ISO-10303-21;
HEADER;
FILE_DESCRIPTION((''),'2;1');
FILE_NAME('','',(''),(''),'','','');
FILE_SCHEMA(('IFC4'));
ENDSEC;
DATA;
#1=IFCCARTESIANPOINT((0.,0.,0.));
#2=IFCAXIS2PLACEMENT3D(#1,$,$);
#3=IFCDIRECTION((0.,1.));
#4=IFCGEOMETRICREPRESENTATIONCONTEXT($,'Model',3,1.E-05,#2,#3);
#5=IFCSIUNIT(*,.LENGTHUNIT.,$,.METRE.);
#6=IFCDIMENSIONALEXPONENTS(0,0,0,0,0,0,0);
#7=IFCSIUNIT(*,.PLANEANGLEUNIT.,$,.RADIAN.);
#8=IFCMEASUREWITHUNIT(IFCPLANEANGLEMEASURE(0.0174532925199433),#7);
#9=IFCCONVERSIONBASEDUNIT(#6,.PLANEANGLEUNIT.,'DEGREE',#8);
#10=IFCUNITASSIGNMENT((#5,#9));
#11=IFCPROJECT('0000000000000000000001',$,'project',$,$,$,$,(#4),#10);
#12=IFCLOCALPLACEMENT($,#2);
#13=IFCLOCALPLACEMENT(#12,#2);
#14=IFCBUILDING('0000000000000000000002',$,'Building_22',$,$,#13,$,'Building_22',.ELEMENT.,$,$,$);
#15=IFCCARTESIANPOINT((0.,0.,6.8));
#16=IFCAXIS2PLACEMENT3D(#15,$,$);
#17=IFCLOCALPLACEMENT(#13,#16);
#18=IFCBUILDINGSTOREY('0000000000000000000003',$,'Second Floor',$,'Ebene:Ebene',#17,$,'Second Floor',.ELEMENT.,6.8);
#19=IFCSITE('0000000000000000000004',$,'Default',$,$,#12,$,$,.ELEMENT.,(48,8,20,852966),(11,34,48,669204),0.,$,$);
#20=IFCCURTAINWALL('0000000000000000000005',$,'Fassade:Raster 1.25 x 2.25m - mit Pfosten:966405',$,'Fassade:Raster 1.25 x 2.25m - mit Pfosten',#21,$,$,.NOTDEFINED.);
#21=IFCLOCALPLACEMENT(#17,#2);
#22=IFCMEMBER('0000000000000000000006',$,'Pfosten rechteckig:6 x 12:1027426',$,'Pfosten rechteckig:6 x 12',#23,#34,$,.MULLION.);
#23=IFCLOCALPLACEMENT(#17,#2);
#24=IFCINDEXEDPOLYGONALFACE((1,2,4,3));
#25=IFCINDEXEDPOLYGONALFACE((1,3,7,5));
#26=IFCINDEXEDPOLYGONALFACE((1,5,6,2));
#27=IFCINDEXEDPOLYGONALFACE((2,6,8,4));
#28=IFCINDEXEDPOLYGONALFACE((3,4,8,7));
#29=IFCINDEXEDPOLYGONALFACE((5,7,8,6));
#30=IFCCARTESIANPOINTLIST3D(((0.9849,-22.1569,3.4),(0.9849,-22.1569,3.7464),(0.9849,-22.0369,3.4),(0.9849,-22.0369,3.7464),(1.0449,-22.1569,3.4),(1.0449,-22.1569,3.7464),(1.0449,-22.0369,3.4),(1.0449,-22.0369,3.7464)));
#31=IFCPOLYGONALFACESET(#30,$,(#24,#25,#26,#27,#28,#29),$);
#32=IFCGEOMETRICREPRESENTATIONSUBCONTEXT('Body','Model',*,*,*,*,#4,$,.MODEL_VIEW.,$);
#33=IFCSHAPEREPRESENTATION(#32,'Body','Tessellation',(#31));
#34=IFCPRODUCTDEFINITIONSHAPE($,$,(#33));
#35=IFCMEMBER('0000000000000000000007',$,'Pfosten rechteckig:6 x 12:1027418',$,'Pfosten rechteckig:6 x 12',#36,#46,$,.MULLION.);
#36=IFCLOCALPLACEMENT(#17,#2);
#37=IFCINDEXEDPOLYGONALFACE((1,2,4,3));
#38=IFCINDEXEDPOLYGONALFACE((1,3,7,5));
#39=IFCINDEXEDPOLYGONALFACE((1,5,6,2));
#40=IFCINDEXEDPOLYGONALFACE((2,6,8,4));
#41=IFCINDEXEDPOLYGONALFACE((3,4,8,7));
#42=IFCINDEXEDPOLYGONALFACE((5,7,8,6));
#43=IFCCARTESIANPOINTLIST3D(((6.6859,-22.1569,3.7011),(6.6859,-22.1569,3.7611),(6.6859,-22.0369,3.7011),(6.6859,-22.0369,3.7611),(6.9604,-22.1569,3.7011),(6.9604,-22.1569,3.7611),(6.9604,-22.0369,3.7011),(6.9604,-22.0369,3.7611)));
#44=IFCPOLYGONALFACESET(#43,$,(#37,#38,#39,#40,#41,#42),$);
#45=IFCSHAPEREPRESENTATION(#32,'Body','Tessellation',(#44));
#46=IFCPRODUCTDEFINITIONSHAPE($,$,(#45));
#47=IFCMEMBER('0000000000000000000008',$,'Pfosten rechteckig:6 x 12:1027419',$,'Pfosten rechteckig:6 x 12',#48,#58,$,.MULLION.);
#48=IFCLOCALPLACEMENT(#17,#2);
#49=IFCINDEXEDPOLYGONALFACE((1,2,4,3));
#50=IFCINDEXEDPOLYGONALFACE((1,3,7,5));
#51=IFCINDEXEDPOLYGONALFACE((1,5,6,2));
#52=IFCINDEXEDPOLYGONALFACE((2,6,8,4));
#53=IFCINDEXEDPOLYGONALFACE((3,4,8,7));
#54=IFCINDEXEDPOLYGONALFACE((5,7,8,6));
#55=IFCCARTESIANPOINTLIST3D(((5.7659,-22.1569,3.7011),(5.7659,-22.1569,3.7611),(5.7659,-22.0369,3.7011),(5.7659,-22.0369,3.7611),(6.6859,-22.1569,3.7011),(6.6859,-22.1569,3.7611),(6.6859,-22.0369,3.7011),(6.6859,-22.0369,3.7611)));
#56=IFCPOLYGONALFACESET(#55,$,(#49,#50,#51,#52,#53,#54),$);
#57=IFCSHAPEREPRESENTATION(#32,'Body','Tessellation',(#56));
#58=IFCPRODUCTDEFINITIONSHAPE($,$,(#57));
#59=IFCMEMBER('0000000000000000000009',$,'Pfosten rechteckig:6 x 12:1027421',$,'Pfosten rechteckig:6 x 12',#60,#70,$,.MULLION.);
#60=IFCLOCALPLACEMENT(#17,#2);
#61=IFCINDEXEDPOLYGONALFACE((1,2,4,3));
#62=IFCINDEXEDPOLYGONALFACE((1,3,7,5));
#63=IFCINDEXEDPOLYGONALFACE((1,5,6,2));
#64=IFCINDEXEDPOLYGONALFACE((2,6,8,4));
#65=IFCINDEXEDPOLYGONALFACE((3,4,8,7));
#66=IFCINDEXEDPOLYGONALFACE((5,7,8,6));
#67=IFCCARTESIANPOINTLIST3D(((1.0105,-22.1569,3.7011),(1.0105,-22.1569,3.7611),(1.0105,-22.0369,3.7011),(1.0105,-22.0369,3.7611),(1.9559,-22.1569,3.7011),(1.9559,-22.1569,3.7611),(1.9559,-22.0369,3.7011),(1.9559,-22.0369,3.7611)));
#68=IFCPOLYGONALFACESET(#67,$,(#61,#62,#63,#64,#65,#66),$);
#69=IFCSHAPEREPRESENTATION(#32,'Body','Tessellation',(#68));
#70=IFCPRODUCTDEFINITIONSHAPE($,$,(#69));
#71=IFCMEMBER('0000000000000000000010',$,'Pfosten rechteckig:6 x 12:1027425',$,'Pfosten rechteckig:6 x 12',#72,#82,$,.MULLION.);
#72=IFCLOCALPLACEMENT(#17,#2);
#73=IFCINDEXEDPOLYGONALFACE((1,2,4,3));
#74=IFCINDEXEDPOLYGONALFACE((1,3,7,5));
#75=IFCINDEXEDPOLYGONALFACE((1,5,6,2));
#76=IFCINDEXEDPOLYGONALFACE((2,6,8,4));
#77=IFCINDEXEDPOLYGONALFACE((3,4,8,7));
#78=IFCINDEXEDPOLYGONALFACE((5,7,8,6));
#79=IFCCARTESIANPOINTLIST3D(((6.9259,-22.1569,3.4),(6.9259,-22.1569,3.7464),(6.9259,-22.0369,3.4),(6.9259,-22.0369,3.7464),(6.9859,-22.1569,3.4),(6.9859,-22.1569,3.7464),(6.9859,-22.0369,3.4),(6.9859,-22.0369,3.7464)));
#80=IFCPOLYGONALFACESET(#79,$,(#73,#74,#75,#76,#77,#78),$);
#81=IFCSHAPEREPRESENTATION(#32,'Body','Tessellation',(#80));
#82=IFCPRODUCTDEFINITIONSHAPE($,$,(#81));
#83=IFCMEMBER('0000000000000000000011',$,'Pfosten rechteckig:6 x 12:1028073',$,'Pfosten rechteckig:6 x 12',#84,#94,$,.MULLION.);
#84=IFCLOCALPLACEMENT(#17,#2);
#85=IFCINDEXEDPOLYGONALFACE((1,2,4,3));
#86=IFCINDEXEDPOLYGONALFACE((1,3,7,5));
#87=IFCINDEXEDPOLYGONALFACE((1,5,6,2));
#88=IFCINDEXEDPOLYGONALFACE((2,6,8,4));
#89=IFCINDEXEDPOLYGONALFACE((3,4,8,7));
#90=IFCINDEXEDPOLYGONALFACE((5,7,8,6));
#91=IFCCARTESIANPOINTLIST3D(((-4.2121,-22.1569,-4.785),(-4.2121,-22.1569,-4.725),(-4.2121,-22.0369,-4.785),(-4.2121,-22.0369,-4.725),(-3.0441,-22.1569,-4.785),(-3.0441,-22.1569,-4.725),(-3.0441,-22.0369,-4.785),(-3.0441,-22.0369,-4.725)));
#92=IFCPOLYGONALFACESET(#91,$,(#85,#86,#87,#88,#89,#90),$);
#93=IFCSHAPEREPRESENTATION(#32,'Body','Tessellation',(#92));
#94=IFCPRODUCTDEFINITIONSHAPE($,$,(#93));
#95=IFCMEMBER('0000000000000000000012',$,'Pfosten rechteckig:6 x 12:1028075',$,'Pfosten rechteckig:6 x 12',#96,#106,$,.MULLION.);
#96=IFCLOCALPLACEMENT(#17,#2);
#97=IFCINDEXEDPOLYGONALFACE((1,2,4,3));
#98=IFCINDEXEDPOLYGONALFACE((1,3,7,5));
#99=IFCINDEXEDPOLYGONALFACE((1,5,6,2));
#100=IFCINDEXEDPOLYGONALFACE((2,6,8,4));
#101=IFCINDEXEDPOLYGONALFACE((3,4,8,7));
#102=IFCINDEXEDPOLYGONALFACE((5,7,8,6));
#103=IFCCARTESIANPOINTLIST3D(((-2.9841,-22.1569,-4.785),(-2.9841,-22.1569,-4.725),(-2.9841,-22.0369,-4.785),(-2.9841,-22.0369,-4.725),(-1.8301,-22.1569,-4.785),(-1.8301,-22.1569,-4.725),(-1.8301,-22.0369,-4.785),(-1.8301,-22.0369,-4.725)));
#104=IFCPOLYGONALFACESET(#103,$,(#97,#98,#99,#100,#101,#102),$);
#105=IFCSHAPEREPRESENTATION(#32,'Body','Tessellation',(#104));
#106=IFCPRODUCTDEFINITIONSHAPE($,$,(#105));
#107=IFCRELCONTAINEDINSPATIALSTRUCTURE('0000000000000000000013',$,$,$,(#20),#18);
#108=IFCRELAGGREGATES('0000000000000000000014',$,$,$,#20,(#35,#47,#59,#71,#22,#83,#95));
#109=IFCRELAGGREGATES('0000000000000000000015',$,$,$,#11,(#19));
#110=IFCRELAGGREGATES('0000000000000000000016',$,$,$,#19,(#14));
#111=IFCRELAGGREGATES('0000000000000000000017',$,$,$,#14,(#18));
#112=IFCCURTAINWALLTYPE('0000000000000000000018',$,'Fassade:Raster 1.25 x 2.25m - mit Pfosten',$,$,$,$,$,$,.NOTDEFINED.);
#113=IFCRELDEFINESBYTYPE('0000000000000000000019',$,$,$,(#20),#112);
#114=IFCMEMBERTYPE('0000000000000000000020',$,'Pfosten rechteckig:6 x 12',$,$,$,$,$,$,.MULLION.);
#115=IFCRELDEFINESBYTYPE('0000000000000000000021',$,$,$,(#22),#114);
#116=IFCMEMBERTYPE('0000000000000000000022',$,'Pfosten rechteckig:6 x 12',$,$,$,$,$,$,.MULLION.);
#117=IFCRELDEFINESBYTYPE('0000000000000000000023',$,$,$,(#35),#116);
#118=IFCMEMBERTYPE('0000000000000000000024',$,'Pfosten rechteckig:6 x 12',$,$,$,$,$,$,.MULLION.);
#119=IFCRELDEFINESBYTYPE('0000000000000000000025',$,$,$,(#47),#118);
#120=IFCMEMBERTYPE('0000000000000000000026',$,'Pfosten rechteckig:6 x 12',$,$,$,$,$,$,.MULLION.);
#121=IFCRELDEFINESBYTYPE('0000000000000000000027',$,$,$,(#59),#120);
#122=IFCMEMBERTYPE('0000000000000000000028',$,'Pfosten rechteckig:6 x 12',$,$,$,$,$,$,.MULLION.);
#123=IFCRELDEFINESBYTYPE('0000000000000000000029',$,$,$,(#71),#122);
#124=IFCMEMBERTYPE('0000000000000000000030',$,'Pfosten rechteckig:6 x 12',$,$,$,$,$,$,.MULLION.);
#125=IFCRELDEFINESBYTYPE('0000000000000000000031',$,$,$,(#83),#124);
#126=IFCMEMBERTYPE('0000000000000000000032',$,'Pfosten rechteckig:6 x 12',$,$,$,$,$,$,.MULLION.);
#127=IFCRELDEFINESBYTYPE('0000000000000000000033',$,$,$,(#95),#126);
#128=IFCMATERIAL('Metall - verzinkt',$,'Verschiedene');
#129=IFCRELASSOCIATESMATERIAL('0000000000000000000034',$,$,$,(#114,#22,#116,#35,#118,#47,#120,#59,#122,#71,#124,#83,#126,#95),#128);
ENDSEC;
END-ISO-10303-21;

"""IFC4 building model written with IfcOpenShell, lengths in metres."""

from ifc_helpers import new_model, entity, si_unit, converted_unit, direction, frame, origin, place, context, subcontext, project, spatial, indexed_curve, outline, extrude, source, transform, mapped, material, type_object, type_shapes, element, aggregate, save


model = new_model("IFC4")

# Units and contexts
model_context = context("Model", 3, precision=1e-05, world=origin(), true_north=direction((0.0, 1.0)))
body_context = subcontext(model_context, "Body", "Model", "MODEL_VIEW")
ifc_project = project(units=[si_unit("LENGTHUNIT", "METRE"), converted_unit("PLANEANGLEUNIT", "DEGREE", entity("IfcPlaneAngleMeasure", 0.0174532925199433), si_unit("PLANEANGLEUNIT", "RADIAN"), dimensions=[0, 0, 0, 0, 0, 0, 0])], contexts=[model_context])

# Site, building, storey
site_placement = place(None, origin())
site = spatial("IfcSite", under=ifc_project, at=site_placement, Name="Default", CompositionType="ELEMENT", RefLatitude=(48, 8, 20, 852966), RefLongitude=(11, 34, 48, 669204), RefElevation=0.0)
building_placement = place(site_placement, origin())
building = spatial("IfcBuilding", under=site, at=building_placement, Name="Building_22", LongName="Building_22", CompositionType="ELEMENT")
storey_placement = place(building_placement, frame((0.0, 0.0, 6.8)))
storey = spatial("IfcBuildingStorey", under=building, at=storey_placement, Name="Second Floor", ObjectType="Ebene:Ebene", LongName="Second Floor", CompositionType="ELEMENT", Elevation=6.8)

# Curtain wall, members
curtain_wall_type = type_object("IfcCurtainWallType", Name="Fassade:Raster 1.25 x 2.25m - mit Pfosten", PredefinedType="NOTDEFINED")
curtain_wall_placement = place(storey_placement, frame((0.0, 0.0, -6.8)))
curtain_wall = element("IfcCurtainWall", 1, at=curtain_wall_placement, inside=storey, type_object=curtain_wall_type, Name="Fassade:Raster 1.25 x 2.25m - mit Pfosten:966405", ObjectType="Fassade:Raster 1.25 x 2.25m - mit Pfosten", PredefinedType="NOTDEFINED")
ifc_material = material(Name="Metall - verzinkt", Category="Verschiedene")
member_type_1 = type_object("IfcMemberType", Name="Pfosten rechteckig:6 x 12", PredefinedType="MULLION", material=ifc_material)
shared_shape_1 = source(origin(), body_context, "Body", "SweptSolid", [
    extrude(outline(indexed_curve([(-0.03, -0.06), (0.03, -0.06), (0.03, 0.06), (-0.03, 0.06), (-0.03, -0.06)], self_intersect=False)), frame((-0.03, 0.0, -0.3464), z_axis=(0.0, 0.0, 1.0), x_axis=(-1.0, 0.0, 0.0)), (0.0, 0.0, 1.0), 0.3464),
])
type_shapes(member_type_1, [shared_shape_1])
member_1_placement = place(curtain_wall_placement, frame((0.9849, -22.0969, 10.5464), z_axis=(0.0, 0.0, 1.0), x_axis=(-1.0, 0.0, 0.0)))
member_1 = element("IfcMember", 2, at=member_1_placement, type_object=member_type_1, material=ifc_material, Name="Pfosten rechteckig:6 x 12:1027426", ObjectType="Pfosten rechteckig:6 x 12", PredefinedType="MULLION", context=body_context, shape_type="MappedRepresentation", body=[
    mapped(shared_shape_1, transform((0.0, 0.0, 0.0), scale=1.0)),
])
member_type_2 = type_object("IfcMemberType", Name="Pfosten rechteckig:6 x 12", PredefinedType="MULLION", material=ifc_material)
shared_shape_2 = source(origin(), body_context, "Body", "SweptSolid", [
    extrude(outline(indexed_curve([(-0.03, -0.06), (0.03, -0.06), (0.03, 0.06), (-0.03, 0.06), (-0.03, -0.06)], self_intersect=False)), frame((-0.03, 0.0, -0.2745), z_axis=(0.0, 0.0, 1.0), x_axis=(-1.0, 0.0, 0.0)), (0.0, 0.0, 1.0), 0.2745),
])
type_shapes(member_type_2, [shared_shape_2])
member_2_placement = place(curtain_wall_placement, frame((6.9604, -22.0969, 10.5611), z_axis=(1.0, 0.0, 0.0), x_axis=(0.0, 0.0, 1.0)))
member_2 = element("IfcMember", 3, at=member_2_placement, type_object=member_type_2, material=ifc_material, Name="Pfosten rechteckig:6 x 12:1027418", ObjectType="Pfosten rechteckig:6 x 12", PredefinedType="MULLION", context=body_context, shape_type="MappedRepresentation", body=[
    mapped(shared_shape_2, transform((0.0, 0.0, 0.0), scale=1.0)),
])
member_type_3 = type_object("IfcMemberType", Name="Pfosten rechteckig:6 x 12", PredefinedType="MULLION", material=ifc_material)
shared_shape_3 = source(origin(), body_context, "Body", "SweptSolid", [
    extrude(outline(indexed_curve([(-0.03, -0.06), (0.03, -0.06), (0.03, 0.06), (-0.03, 0.06), (-0.03, -0.06)], self_intersect=False)), frame((-0.03, 0.0, -0.92), z_axis=(0.0, 0.0, 1.0), x_axis=(-1.0, 0.0, 0.0)), (0.0, 0.0, 1.0), 0.92),
])
type_shapes(member_type_3, [shared_shape_3])
member_3_placement = place(curtain_wall_placement, frame((6.6859, -22.0969, 10.5611), z_axis=(1.0, 0.0, 0.0), x_axis=(0.0, 0.0, 1.0)))
member_3 = element("IfcMember", 4, at=member_3_placement, type_object=member_type_3, material=ifc_material, Name="Pfosten rechteckig:6 x 12:1027419", ObjectType="Pfosten rechteckig:6 x 12", PredefinedType="MULLION", context=body_context, shape_type="MappedRepresentation", body=[
    mapped(shared_shape_3, transform((0.0, 0.0, 0.0), scale=1.0)),
])
member_type_4 = type_object("IfcMemberType", Name="Pfosten rechteckig:6 x 12", PredefinedType="MULLION", material=ifc_material)
shared_shape_4 = source(origin(), body_context, "Body", "SweptSolid", [
    extrude(outline(indexed_curve([(-0.03, -0.06), (0.03, -0.06), (0.03, 0.06), (-0.03, 0.06), (-0.03, -0.06)], self_intersect=False)), frame((-0.03, 0.0, -0.9455), z_axis=(0.0, 0.0, 1.0), x_axis=(-1.0, 0.0, 0.0)), (0.0, 0.0, 1.0), 0.9455),
])
type_shapes(member_type_4, [shared_shape_4])
member_4_placement = place(curtain_wall_placement, frame((1.9559, -22.0969, 10.5611), z_axis=(1.0, 0.0, 0.0), x_axis=(0.0, 0.0, 1.0)))
member_4 = element("IfcMember", 5, at=member_4_placement, type_object=member_type_4, material=ifc_material, Name="Pfosten rechteckig:6 x 12:1027421", ObjectType="Pfosten rechteckig:6 x 12", PredefinedType="MULLION", context=body_context, shape_type="MappedRepresentation", body=[
    mapped(shared_shape_4, transform((0.0, 0.0, 0.0), scale=1.0)),
])
member_type_5 = type_object("IfcMemberType", Name="Pfosten rechteckig:6 x 12", PredefinedType="MULLION", material=ifc_material)
shared_shape_5 = source(origin(), body_context, "Body", "SweptSolid", [
    extrude(outline(indexed_curve([(-0.03, -0.06), (0.03, -0.06), (0.03, 0.06), (-0.03, 0.06), (-0.03, -0.06)], self_intersect=False)), frame((-0.03, 0.0, -0.3464), z_axis=(0.0, 0.0, 1.0), x_axis=(-1.0, 0.0, 0.0)), (0.0, 0.0, 1.0), 0.3464),
])
type_shapes(member_type_5, [shared_shape_5])
member_5_placement = place(curtain_wall_placement, frame((6.9859, -22.0969, 10.2), z_axis=(0.0, 0.0, -1.0), x_axis=(1.0, 0.0, 0.0)))
member_5 = element("IfcMember", 6, at=member_5_placement, type_object=member_type_5, material=ifc_material, Name="Pfosten rechteckig:6 x 12:1027425", ObjectType="Pfosten rechteckig:6 x 12", PredefinedType="MULLION", context=body_context, shape_type="MappedRepresentation", body=[
    mapped(shared_shape_5, transform((0.0, 0.0, 0.0), scale=1.0)),
])
member_type_6 = type_object("IfcMemberType", Name="Pfosten rechteckig:6 x 12", PredefinedType="MULLION", material=ifc_material)
shared_shape_6 = source(origin(), body_context, "Body", "SweptSolid", [
    extrude(outline(indexed_curve([(-0.03, -0.06), (0.03, -0.06), (0.03, 0.06), (-0.03, 0.06), (-0.03, -0.06)], self_intersect=False)), frame((-0.03, 0.0, -1.168), z_axis=(0.0, 0.0, 1.0), x_axis=(-1.0, 0.0, 0.0)), (0.0, 0.0, 1.0), 1.168),
])
type_shapes(member_type_6, [shared_shape_6])
member_6_placement = place(curtain_wall_placement, frame((-4.2121, -22.0969, 2.015), z_axis=(-1.0, 0.0, 0.0), x_axis=(0.0, 0.0, -1.0)))
member_6 = element("IfcMember", 7, at=member_6_placement, type_object=member_type_6, material=ifc_material, Name="Pfosten rechteckig:6 x 12:1028073", ObjectType="Pfosten rechteckig:6 x 12", PredefinedType="MULLION", context=body_context, shape_type="MappedRepresentation", body=[
    mapped(shared_shape_6, transform((0.0, 0.0, 0.0), scale=1.0)),
])
member_type_7 = type_object("IfcMemberType", Name="Pfosten rechteckig:6 x 12", PredefinedType="MULLION", material=ifc_material)
shared_shape_7 = source(origin(), body_context, "Body", "SweptSolid", [
    extrude(outline(indexed_curve([(-0.03, -0.06), (0.03, -0.06), (0.03, 0.06), (-0.03, 0.06), (-0.03, -0.06)], self_intersect=False)), frame((-0.03, 0.0, -1.154), z_axis=(0.0, 0.0, 1.0), x_axis=(-1.0, 0.0, 0.0)), (0.0, 0.0, 1.0), 1.154),
])
type_shapes(member_type_7, [shared_shape_7])
member_7_placement = place(curtain_wall_placement, frame((-2.9841, -22.0969, 2.015), z_axis=(-1.0, 0.0, 0.0), x_axis=(0.0, 0.0, -1.0)))
member_7 = element("IfcMember", 8, at=member_7_placement, type_object=member_type_7, material=ifc_material, Name="Pfosten rechteckig:6 x 12:1028075", ObjectType="Pfosten rechteckig:6 x 12", PredefinedType="MULLION", context=body_context, shape_type="MappedRepresentation", body=[
    mapped(shared_shape_7, transform((0.0, 0.0, 0.0), scale=1.0)),
])
aggregate(curtain_wall, [member_2, member_3, member_4, member_5, member_1, member_6, member_7])

save(model, "model.ifc")
